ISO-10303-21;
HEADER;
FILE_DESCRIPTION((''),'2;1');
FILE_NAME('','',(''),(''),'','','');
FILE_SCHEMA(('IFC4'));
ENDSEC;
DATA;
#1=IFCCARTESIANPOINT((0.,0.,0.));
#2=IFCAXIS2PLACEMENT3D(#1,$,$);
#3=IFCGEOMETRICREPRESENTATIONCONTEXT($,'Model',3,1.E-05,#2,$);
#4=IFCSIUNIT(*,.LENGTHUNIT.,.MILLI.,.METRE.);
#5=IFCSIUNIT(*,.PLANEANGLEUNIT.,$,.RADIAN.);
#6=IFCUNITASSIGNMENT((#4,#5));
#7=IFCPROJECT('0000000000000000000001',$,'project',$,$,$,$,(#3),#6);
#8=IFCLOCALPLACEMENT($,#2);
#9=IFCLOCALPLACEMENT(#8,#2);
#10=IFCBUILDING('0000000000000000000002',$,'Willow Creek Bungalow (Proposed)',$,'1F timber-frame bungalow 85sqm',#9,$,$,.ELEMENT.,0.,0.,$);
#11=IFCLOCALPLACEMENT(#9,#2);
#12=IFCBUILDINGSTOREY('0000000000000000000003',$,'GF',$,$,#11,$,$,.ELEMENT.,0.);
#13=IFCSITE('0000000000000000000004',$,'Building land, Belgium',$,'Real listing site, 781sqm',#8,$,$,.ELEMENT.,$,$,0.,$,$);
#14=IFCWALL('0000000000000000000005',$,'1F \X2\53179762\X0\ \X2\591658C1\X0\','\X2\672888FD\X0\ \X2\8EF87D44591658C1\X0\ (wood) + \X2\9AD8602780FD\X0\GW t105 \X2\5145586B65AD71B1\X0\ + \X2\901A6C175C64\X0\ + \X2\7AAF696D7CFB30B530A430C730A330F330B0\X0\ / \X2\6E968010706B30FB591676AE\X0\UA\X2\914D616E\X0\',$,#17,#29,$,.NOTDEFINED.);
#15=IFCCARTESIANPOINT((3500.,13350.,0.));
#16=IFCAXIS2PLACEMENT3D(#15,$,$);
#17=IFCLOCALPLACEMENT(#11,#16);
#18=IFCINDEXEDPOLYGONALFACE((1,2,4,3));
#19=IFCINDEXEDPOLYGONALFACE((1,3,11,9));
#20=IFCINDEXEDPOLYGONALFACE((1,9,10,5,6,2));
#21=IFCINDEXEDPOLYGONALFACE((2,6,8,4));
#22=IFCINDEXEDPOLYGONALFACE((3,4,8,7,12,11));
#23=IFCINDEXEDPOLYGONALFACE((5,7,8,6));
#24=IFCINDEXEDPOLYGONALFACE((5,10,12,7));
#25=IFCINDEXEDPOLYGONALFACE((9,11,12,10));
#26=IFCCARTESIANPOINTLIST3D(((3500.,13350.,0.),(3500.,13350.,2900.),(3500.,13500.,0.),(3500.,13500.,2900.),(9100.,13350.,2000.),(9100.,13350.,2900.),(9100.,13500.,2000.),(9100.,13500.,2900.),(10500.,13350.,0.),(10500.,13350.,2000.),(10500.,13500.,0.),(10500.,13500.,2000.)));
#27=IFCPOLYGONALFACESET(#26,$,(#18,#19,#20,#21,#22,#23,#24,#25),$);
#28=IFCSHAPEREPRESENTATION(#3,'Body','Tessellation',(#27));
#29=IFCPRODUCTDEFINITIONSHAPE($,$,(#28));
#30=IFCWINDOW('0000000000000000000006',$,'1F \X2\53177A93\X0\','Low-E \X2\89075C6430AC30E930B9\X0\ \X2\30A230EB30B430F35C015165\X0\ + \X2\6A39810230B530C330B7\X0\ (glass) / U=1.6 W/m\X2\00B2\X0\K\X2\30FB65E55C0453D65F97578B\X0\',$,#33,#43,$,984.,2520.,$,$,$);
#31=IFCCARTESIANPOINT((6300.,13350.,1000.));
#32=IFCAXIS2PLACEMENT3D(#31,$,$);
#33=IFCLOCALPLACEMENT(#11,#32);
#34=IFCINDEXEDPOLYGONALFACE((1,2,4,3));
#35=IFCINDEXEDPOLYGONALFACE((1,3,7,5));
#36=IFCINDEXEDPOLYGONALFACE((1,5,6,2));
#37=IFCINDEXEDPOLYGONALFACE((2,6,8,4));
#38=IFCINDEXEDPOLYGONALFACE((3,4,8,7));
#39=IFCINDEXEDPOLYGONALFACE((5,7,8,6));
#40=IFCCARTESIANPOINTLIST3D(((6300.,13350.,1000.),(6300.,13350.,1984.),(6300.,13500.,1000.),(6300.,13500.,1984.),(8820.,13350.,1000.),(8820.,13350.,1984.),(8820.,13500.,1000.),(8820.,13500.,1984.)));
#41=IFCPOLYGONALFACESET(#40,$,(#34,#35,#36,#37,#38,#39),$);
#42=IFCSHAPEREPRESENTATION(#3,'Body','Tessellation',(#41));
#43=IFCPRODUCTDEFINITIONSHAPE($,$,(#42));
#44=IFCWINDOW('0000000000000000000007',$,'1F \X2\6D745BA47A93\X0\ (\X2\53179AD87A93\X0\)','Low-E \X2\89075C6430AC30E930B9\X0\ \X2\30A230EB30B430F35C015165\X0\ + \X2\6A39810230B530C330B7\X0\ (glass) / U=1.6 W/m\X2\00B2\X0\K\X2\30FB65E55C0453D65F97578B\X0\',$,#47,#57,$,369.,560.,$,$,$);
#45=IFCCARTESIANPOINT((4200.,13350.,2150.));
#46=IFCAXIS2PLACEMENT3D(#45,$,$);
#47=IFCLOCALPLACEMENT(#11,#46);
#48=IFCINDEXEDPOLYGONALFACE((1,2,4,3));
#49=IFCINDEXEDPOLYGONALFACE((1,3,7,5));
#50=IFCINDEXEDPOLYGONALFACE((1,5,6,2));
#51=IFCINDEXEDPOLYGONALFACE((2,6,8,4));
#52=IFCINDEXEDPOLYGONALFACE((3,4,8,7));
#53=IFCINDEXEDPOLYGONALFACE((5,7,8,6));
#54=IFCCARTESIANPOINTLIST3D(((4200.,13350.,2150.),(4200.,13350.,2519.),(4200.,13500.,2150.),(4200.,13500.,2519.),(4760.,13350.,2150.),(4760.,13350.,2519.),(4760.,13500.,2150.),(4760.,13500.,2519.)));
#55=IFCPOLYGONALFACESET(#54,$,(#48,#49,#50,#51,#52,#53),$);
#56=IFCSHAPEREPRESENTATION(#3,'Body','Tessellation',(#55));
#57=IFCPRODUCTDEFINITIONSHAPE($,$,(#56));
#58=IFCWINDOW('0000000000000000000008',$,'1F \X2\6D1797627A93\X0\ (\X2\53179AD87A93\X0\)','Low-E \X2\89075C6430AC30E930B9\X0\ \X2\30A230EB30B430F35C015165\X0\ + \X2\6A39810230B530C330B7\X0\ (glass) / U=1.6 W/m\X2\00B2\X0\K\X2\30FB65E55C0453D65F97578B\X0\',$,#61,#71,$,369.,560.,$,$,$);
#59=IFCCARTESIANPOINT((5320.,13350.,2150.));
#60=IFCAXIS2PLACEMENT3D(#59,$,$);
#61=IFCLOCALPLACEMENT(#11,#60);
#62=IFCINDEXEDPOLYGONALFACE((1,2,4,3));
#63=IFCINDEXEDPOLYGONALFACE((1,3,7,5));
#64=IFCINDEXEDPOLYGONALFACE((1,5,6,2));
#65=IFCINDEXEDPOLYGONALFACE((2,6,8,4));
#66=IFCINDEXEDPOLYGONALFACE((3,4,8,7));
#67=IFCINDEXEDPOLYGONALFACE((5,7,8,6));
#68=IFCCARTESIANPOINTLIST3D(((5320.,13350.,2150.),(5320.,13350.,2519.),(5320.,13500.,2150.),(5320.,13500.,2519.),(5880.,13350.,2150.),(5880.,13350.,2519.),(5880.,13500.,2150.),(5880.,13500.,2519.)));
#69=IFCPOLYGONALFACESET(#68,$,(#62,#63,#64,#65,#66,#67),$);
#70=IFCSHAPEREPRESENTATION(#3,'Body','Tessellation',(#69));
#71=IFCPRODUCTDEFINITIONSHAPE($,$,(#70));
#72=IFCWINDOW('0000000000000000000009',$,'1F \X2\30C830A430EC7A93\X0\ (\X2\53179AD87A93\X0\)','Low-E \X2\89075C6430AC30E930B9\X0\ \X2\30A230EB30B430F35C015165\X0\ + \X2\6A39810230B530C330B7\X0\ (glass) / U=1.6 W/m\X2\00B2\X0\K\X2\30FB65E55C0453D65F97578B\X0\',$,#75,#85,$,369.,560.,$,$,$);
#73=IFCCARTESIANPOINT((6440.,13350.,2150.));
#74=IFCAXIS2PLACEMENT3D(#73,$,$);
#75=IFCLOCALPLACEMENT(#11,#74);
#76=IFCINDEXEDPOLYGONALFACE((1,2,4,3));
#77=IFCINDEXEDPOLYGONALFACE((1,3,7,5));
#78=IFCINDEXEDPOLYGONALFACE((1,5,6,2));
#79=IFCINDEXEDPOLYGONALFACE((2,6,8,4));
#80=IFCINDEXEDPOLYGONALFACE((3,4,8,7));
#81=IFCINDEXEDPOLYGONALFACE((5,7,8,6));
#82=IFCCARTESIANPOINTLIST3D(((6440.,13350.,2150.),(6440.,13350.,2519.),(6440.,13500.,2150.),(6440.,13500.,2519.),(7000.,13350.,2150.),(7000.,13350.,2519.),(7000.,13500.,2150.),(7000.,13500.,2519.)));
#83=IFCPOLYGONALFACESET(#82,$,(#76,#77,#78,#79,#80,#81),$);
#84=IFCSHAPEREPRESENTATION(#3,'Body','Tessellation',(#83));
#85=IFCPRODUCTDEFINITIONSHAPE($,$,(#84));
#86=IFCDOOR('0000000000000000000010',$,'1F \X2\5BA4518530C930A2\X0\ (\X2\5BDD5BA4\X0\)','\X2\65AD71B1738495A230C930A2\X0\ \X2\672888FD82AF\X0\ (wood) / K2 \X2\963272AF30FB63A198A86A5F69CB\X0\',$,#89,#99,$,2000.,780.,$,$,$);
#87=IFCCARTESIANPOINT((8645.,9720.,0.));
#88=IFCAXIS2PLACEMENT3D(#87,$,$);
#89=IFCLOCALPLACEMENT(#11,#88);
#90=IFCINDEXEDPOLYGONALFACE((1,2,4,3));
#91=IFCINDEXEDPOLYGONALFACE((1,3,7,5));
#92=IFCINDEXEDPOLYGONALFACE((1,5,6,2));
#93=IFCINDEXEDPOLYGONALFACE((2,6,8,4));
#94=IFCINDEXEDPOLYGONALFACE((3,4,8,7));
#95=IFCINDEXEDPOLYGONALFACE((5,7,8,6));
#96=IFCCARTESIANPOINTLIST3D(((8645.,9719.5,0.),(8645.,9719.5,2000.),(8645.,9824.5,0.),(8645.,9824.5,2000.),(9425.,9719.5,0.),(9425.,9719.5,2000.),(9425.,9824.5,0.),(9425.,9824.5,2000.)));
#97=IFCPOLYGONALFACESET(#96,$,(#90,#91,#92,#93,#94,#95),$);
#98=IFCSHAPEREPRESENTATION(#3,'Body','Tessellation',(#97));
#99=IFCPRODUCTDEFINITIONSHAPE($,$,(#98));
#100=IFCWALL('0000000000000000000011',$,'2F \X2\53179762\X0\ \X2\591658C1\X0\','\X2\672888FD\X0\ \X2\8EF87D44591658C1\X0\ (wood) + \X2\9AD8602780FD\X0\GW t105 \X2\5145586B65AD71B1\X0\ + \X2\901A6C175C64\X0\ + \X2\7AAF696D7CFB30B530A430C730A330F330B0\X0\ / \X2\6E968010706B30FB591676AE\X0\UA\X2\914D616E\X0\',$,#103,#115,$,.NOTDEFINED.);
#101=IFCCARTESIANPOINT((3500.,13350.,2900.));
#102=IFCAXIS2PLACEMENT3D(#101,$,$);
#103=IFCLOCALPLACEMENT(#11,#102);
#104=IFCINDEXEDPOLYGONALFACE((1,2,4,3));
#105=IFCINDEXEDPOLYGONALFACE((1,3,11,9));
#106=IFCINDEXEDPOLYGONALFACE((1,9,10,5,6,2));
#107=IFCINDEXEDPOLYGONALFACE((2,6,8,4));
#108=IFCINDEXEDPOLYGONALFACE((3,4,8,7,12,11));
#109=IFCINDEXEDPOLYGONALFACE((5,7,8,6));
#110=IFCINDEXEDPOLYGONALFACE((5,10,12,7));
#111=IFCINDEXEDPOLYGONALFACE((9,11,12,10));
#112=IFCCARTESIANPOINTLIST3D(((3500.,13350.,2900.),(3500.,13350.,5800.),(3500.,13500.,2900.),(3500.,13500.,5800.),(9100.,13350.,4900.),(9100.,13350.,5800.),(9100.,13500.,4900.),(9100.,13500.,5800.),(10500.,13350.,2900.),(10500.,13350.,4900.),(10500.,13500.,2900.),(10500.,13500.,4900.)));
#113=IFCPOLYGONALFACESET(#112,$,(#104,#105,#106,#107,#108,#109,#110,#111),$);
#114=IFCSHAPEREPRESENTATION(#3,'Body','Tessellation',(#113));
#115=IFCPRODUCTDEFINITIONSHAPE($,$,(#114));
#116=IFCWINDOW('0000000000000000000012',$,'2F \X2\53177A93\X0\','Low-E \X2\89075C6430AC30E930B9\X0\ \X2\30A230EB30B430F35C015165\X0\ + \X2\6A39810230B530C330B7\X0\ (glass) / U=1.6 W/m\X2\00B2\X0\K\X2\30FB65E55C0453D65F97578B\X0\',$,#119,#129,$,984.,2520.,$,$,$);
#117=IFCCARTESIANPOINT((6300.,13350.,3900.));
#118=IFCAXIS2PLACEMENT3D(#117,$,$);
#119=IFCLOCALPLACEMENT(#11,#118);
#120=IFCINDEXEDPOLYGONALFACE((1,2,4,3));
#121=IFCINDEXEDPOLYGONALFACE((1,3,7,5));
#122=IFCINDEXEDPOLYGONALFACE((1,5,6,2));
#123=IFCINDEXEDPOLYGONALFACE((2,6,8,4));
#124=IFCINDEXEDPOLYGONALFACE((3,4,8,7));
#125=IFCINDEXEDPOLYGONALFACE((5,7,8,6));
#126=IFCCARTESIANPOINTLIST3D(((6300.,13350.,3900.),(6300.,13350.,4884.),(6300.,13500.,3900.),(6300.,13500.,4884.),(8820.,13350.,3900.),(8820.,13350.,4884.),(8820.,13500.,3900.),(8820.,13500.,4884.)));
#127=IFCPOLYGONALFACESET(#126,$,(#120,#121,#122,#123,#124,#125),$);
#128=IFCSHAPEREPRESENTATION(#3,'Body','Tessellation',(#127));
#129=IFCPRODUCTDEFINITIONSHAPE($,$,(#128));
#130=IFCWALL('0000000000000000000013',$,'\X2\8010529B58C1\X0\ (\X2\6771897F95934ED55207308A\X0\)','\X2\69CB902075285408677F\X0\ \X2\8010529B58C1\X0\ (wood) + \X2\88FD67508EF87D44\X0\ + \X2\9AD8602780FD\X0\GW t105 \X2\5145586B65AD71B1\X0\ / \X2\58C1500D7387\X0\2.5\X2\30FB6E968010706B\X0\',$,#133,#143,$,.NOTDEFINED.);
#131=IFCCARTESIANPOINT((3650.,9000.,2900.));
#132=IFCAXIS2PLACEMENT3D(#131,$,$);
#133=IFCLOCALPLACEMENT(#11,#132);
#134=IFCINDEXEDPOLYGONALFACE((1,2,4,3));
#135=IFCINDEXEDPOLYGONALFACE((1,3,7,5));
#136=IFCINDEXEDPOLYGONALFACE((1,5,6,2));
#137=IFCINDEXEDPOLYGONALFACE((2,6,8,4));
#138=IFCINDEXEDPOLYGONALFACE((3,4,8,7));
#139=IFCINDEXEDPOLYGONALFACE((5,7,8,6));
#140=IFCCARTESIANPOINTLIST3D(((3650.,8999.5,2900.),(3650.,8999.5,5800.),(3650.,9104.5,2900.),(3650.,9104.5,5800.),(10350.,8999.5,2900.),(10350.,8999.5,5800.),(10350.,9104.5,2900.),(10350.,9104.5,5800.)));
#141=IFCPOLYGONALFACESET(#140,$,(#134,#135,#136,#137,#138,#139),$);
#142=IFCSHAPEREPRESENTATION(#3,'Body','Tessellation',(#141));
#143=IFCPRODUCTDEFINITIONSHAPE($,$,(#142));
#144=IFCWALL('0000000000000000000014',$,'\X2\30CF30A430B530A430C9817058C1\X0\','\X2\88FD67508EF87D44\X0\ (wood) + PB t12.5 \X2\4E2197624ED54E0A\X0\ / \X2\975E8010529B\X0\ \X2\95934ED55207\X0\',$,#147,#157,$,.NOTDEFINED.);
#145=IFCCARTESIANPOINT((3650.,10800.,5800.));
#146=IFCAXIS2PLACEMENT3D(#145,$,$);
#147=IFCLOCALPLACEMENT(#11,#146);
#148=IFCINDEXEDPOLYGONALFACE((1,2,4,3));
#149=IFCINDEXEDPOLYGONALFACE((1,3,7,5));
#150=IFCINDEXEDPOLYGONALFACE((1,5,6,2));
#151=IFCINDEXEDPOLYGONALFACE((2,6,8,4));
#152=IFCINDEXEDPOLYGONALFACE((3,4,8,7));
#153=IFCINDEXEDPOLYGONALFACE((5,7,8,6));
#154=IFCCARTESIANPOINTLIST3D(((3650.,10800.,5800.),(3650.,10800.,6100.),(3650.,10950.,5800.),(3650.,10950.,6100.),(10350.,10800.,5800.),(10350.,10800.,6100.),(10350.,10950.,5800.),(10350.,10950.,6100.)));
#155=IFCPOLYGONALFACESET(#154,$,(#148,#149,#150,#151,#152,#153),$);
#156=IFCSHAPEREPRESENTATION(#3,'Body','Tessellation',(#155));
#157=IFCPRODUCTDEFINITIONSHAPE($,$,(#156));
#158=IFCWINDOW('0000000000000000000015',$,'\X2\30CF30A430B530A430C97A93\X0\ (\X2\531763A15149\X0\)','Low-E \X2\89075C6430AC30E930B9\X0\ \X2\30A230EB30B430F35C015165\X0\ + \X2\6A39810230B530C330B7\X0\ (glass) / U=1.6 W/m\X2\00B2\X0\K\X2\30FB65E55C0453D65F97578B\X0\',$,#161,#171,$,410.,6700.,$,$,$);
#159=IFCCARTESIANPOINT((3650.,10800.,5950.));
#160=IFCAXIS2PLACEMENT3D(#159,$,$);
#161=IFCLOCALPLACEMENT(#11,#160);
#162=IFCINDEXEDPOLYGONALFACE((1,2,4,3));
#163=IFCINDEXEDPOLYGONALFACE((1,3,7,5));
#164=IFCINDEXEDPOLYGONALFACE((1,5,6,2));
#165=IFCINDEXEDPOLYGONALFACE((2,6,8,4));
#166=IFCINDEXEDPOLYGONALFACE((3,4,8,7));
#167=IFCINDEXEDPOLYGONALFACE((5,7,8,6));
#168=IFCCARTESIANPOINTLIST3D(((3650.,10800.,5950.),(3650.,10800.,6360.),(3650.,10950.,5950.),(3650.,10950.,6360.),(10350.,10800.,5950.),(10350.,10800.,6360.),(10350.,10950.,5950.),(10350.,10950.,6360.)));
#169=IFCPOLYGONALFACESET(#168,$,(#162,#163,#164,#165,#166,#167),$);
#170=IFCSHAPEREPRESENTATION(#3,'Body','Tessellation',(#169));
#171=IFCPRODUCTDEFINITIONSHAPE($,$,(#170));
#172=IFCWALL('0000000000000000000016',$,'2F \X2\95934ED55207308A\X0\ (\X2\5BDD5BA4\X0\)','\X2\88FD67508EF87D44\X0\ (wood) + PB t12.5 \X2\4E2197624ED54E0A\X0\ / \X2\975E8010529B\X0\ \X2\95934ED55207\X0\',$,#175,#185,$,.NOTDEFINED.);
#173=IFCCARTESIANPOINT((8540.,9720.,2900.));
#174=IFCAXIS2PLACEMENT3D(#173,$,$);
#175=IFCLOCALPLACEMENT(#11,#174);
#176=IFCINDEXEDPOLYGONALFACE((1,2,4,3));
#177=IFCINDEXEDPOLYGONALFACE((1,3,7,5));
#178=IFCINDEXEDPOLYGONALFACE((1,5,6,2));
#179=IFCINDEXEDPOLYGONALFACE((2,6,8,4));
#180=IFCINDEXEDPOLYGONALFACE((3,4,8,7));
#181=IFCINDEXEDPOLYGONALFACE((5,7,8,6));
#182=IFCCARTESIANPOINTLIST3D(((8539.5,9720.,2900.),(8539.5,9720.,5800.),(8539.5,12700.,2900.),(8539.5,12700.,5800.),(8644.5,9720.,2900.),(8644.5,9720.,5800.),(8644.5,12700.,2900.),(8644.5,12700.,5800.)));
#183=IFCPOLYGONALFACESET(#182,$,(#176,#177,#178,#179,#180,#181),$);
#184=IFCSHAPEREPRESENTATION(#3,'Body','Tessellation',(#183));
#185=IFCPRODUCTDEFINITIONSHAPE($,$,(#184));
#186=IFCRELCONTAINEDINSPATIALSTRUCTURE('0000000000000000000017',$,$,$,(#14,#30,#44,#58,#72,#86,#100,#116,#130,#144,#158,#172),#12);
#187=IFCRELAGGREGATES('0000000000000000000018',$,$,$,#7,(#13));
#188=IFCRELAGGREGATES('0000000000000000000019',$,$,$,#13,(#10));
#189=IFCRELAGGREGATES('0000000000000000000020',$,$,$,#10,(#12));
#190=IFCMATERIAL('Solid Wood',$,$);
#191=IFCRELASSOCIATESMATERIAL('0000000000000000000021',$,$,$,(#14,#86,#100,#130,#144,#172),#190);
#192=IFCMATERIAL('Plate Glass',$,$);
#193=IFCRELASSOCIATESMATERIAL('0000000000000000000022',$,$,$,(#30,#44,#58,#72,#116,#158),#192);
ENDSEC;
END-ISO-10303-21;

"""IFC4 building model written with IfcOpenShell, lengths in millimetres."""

from ifc_helpers import new_model, si_unit, frame, frame_2d, origin, place, context, project, spatial, rectangle, extrude, material, element, fill, save


model = new_model("IFC4")

# Units and contexts
model_context = context("Model", 3, precision=1e-05, world=origin())
ifc_project = project(units=[si_unit("LENGTHUNIT", "METRE", prefix="MILLI"), si_unit("PLANEANGLEUNIT", "RADIAN")], contexts=[model_context])

# Site, building, storey
site_placement = place(None, origin())
site = spatial("IfcSite", under=ifc_project, at=site_placement, Name="Building land, Belgium", ObjectType="Real listing site, 781sqm", CompositionType="ELEMENT", RefElevation=0.0)
building_placement = place(site_placement, origin())
building = spatial("IfcBuilding", under=site, at=building_placement, Name="Willow Creek Bungalow (Proposed)", ObjectType="1F timber-frame bungalow 85sqm", CompositionType="ELEMENT", ElevationOfRefHeight=0.0, ElevationOfTerrain=0.0)
storey_placement = place(building_placement, origin())
storey = spatial("IfcBuildingStorey", under=building, at=storey_placement, Name="GF", CompositionType="ELEMENT", Elevation=0.0)

# Wall, openings, windows
ifc_material_1 = material(Name="Solid Wood")
wall_1_placement = place(storey_placement, frame((3500.0, 13350.0, 0.0)))
wall_1 = element("IfcWall", 1, at=wall_1_placement, inside=storey, material=ifc_material_1, Name="1F 北面 外壁", Description="木製 軸組外壁 (wood) + 高性能GW t105 充填断熱 + 通気層 + 窯業系サイディング / 準耐火・外皮UA配慮", PredefinedType="NOTDEFINED", context=model_context, shape_type="SweptSolid", body=[
    extrude(rectangle(XDim=7000.0, YDim=150.0, at=frame_2d((3500.0, 75.0))), frame((3500.0, 13350.0, 0.0)), (0.0, 0.0, 1.0), 2900.0),
])
opening_1_placement = place(storey_placement, frame((6300.0, 13350.0, 1000.0)))
opening_1 = element("IfcOpeningElement", 2, at=opening_1_placement, cuts=wall_1, PredefinedType="NOTDEFINED", context=model_context, shape_type="SweptSolid", body=[
    extrude(rectangle(XDim=2520.0, YDim=150.0, at=frame_2d((1260.0, 75.0))), frame((6300.0, 13350.0, 1000.0)), (0.0, 0.0, 1.0), 984.0),
])
opening_2_placement = place(storey_placement, frame((4200.0, 13350.0, 2150.0)))
opening_2 = element("IfcOpeningElement", 3, at=opening_2_placement, cuts=wall_1, PredefinedType="NOTDEFINED", context=model_context, shape_type="SweptSolid", body=[
    extrude(rectangle(XDim=560.0, YDim=150.0, at=frame_2d((280.0, 75.0))), frame((4200.0, 13350.0, 2150.0)), (0.0, 0.0, 1.0), 369.0),
])
opening_3_placement = place(storey_placement, frame((5320.0, 13350.0, 2150.0)))
opening_3 = element("IfcOpeningElement", 4, at=opening_3_placement, cuts=wall_1, PredefinedType="NOTDEFINED", context=model_context, shape_type="SweptSolid", body=[
    extrude(rectangle(XDim=560.0, YDim=150.0, at=frame_2d((280.0, 75.0))), frame((5320.0, 13350.0, 2150.0)), (0.0, 0.0, 1.0), 369.0),
])
opening_4_placement = place(storey_placement, frame((6440.0, 13350.0, 2150.0)))
opening_4 = element("IfcOpeningElement", 5, at=opening_4_placement, cuts=wall_1, PredefinedType="NOTDEFINED", context=model_context, shape_type="SweptSolid", body=[
    extrude(rectangle(XDim=560.0, YDim=150.0, at=frame_2d((280.0, 75.0))), frame((6440.0, 13350.0, 2150.0)), (0.0, 0.0, 1.0), 369.0),
])
ifc_material_2 = material(Name="Plate Glass")
window_1_placement = place(storey_placement, frame((6300.0, 13350.0, 1000.0)))
window_1 = element("IfcWindow", 6, at=window_1_placement, inside=storey, material=ifc_material_2, Name="1F 北窓", Description="Low-E 複層ガラス アルゴン封入 + 樹脂サッシ (glass) / U=1.6 W/m²K・日射取得型", OverallHeight=984.0, OverallWidth=2520.0, context=model_context, shape_type="SweptSolid", body=[
    extrude(rectangle(XDim=2520.0, YDim=150.0, at=frame_2d((1260.0, 75.0))), frame((6300.0, 13350.0, 1000.0)), (0.0, 0.0, 1.0), 984.0),
])
fill(opening_1, window_1)
window_2_placement = place(storey_placement, frame((4200.0, 13350.0, 2150.0)))
window_2 = element("IfcWindow", 7, at=window_2_placement, inside=storey, material=ifc_material_2, Name="1F 浴室窓 (北高窓)", Description="Low-E 複層ガラス アルゴン封入 + 樹脂サッシ (glass) / U=1.6 W/m²K・日射取得型", OverallHeight=369.0, OverallWidth=560.0, context=model_context, shape_type="SweptSolid", body=[
    extrude(rectangle(XDim=560.0, YDim=150.0, at=frame_2d((280.0, 75.0))), frame((4200.0, 13350.0, 2150.0)), (0.0, 0.0, 1.0), 369.0),
])
fill(opening_2, window_2)
window_3_placement = place(storey_placement, frame((5320.0, 13350.0, 2150.0)))
window_3 = element("IfcWindow", 8, at=window_3_placement, inside=storey, material=ifc_material_2, Name="1F 洗面窓 (北高窓)", Description="Low-E 複層ガラス アルゴン封入 + 樹脂サッシ (glass) / U=1.6 W/m²K・日射取得型", OverallHeight=369.0, OverallWidth=560.0, context=model_context, shape_type="SweptSolid", body=[
    extrude(rectangle(XDim=560.0, YDim=150.0, at=frame_2d((280.0, 75.0))), frame((5320.0, 13350.0, 2150.0)), (0.0, 0.0, 1.0), 369.0),
])
fill(opening_3, window_3)
window_4_placement = place(storey_placement, frame((6440.0, 13350.0, 2150.0)))
window_4 = element("IfcWindow", 9, at=window_4_placement, inside=storey, material=ifc_material_2, Name="1F トイレ窓 (北高窓)", Description="Low-E 複層ガラス アルゴン封入 + 樹脂サッシ (glass) / U=1.6 W/m²K・日射取得型", OverallHeight=369.0, OverallWidth=560.0, context=model_context, shape_type="SweptSolid", body=[
    extrude(rectangle(XDim=560.0, YDim=150.0, at=frame_2d((280.0, 75.0))), frame((6440.0, 13350.0, 2150.0)), (0.0, 0.0, 1.0), 369.0),
])
fill(opening_4, window_4)

# Door
door_1_placement = place(storey_placement, frame((8645.0, 9720.0, 0.0)))
element("IfcDoor", 10, at=door_1_placement, inside=storey, material=ifc_material_1, Name="1F 室内ドア (寝室)", Description="断熱玄関ドア 木製芯 (wood) / K2 防犯・採風機構", OverallHeight=2000.0, OverallWidth=780.0, context=model_context, shape_type="SweptSolid", body=[
    extrude(rectangle(XDim=780.0, YDim=105.0, at=frame_2d((390.0, 52.0))), frame((8645.0, 9720.0, 0.0)), (0.0, 0.0, 1.0), 2000.0),
])

# Wall, opening, window
wall_2_placement = place(storey_placement, frame((3500.0, 13350.0, 2900.0)))
wall_2 = element("IfcWall", 11, at=wall_2_placement, inside=storey, material=ifc_material_1, Name="2F 北面 外壁", Description="木製 軸組外壁 (wood) + 高性能GW t105 充填断熱 + 通気層 + 窯業系サイディング / 準耐火・外皮UA配慮", PredefinedType="NOTDEFINED", context=model_context, shape_type="SweptSolid", body=[
    extrude(rectangle(XDim=7000.0, YDim=150.0, at=frame_2d((3500.0, 75.0))), frame((3500.0, 13350.0, 2900.0)), (0.0, 0.0, 1.0), 2900.0),
])
opening_5_placement = place(storey_placement, frame((6300.0, 13350.0, 3900.0)))
opening_5 = element("IfcOpeningElement", 12, at=opening_5_placement, cuts=wall_2, PredefinedType="NOTDEFINED", context=model_context, shape_type="SweptSolid", body=[
    extrude(rectangle(XDim=2520.0, YDim=150.0, at=frame_2d((1260.0, 75.0))), frame((6300.0, 13350.0, 3900.0)), (0.0, 0.0, 1.0), 984.0),
])
window_5_placement = place(storey_placement, frame((6300.0, 13350.0, 3900.0)))
window_5 = element("IfcWindow", 13, at=window_5_placement, inside=storey, material=ifc_material_2, Name="2F 北窓", Description="Low-E 複層ガラス アルゴン封入 + 樹脂サッシ (glass) / U=1.6 W/m²K・日射取得型", OverallHeight=984.0, OverallWidth=2520.0, context=model_context, shape_type="SweptSolid", body=[
    extrude(rectangle(XDim=2520.0, YDim=150.0, at=frame_2d((1260.0, 75.0))), frame((6300.0, 13350.0, 3900.0)), (0.0, 0.0, 1.0), 984.0),
])
fill(opening_5, window_5)

# Wall
wall_3_placement = place(storey_placement, frame((3650.0, 9000.0, 2900.0)))
element("IfcWall", 14, at=wall_3_placement, inside=storey, material=ifc_material_1, Name="耐力壁 (東西間仕切り)", Description="構造用合板 耐力壁 (wood) + 製材軸組 + 高性能GW t105 充填断熱 / 壁倍率2.5・準耐火", PredefinedType="NOTDEFINED", context=model_context, shape_type="SweptSolid", body=[
    extrude(rectangle(XDim=6700.0, YDim=105.0, at=frame_2d((3350.0, 52.0))), frame((3650.0, 9000.0, 2900.0)), (0.0, 0.0, 1.0), 2900.0),
])

# Wall, opening, window
wall_4_placement = place(storey_placement, frame((3650.0, 10800.0, 5800.0)))
wall_4 = element("IfcWall", 15, at=wall_4_placement, inside=storey, material=ifc_material_1, Name="ハイサイド腰壁", Description="製材軸組 (wood) + PB t12.5 両面仕上 / 非耐力 間仕切", PredefinedType="NOTDEFINED", context=model_context, shape_type="SweptSolid", body=[
    extrude(rectangle(XDim=6700.0, YDim=150.0, at=frame_2d((3350.0, 75.0))), frame((3650.0, 10800.0, 5800.0)), (0.0, 0.0, 1.0), 700.0),
])
opening_6_placement = place(storey_placement, frame((3650.0, 10800.0, 5950.0)))
opening_6 = element("IfcOpeningElement", 16, at=opening_6_placement, cuts=wall_4, PredefinedType="NOTDEFINED", context=model_context, shape_type="SweptSolid", body=[
    extrude(rectangle(XDim=6700.0, YDim=150.0, at=frame_2d((3350.0, 75.0))), frame((3650.0, 10800.0, 5950.0)), (0.0, 0.0, 1.0), 410.0),
])
window_6_placement = place(storey_placement, frame((3650.0, 10800.0, 5950.0)))
window_6 = element("IfcWindow", 17, at=window_6_placement, inside=storey, material=ifc_material_2, Name="ハイサイド窓 (北採光)", Description="Low-E 複層ガラス アルゴン封入 + 樹脂サッシ (glass) / U=1.6 W/m²K・日射取得型", OverallHeight=410.0, OverallWidth=6700.0, context=model_context, shape_type="SweptSolid", body=[
    extrude(rectangle(XDim=6700.0, YDim=150.0, at=frame_2d((3350.0, 75.0))), frame((3650.0, 10800.0, 5950.0)), (0.0, 0.0, 1.0), 410.0),
])
fill(opening_6, window_6)

# Wall
wall_5_placement = place(storey_placement, frame((8540.0, 9720.0, 2900.0)))
element("IfcWall", 18, at=wall_5_placement, inside=storey, material=ifc_material_1, Name="2F 間仕切り (寝室)", Description="製材軸組 (wood) + PB t12.5 両面仕上 / 非耐力 間仕切", PredefinedType="NOTDEFINED", context=model_context, shape_type="SweptSolid", body=[
    extrude(rectangle(XDim=105.0, YDim=2980.0, at=frame_2d((52.0, 1490.0))), frame((8540.0, 9720.0, 2900.0)), (0.0, 0.0, 1.0), 2900.0),
])

save(model, "model.ifc")
